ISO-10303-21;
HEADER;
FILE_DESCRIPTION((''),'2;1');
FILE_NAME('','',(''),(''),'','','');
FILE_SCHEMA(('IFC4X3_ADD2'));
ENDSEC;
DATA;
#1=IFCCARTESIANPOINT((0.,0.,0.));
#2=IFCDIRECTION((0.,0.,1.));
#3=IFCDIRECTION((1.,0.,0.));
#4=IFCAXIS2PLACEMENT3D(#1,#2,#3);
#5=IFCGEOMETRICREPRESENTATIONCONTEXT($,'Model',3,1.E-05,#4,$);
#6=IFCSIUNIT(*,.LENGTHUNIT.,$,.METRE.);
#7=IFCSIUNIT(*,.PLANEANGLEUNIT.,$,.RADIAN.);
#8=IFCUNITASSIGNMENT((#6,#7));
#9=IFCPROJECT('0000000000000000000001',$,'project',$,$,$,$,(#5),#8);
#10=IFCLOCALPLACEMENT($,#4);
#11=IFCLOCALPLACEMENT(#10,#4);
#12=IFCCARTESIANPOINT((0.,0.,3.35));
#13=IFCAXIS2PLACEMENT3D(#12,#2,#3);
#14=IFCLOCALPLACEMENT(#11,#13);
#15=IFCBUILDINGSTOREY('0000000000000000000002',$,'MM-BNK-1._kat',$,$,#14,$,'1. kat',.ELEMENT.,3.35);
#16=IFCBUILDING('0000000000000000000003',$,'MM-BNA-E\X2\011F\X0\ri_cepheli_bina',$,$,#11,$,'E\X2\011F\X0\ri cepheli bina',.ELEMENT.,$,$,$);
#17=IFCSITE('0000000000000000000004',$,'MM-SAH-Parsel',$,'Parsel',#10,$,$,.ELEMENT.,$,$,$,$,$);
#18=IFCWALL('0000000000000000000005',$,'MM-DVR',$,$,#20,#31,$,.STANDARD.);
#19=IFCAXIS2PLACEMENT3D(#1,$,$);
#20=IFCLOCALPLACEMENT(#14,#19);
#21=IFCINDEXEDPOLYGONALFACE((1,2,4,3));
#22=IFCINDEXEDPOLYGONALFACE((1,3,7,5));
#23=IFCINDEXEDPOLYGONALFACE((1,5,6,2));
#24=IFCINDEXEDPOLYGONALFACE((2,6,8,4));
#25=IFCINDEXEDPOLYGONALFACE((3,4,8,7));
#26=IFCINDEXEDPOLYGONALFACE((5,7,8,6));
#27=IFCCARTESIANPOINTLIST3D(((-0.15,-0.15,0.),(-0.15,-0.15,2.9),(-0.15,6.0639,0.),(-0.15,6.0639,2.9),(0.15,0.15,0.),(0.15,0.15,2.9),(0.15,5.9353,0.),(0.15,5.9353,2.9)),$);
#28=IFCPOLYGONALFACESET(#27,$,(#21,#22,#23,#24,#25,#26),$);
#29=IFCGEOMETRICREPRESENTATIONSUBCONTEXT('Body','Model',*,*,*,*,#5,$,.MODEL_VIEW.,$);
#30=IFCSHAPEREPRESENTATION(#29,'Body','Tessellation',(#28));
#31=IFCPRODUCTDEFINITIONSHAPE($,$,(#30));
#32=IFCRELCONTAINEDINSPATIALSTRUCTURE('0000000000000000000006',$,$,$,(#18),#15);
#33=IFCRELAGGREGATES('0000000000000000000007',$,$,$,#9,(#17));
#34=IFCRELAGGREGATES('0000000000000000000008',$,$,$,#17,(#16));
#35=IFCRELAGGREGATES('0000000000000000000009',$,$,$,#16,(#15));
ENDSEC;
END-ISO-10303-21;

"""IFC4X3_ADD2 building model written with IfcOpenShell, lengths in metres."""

from ifc_helpers import new_model, si_unit, frame, origin, origin_with_axes, place, context, subcontext, project, spatial, polyline, outline, extrude, element, save


model = new_model("IFC4X3_ADD2")

# Units and contexts
model_context = context("Model", 3, precision=1e-05, world=origin_with_axes())
body_context = subcontext(model_context, "Body", "Model", "MODEL_VIEW")
ifc_project = project(units=[si_unit("LENGTHUNIT", "METRE"), si_unit("PLANEANGLEUNIT", "RADIAN")], contexts=[model_context])

# Site, building, storey
site_placement = place(None, origin_with_axes())
site = spatial("IfcSite", under=ifc_project, at=site_placement, Name="MM-SAH-Parsel", ObjectType="Parsel", CompositionType="ELEMENT")
building_placement = place(site_placement, origin_with_axes())
building = spatial("IfcBuilding", under=site, at=building_placement, Name="MM-BNA-Eğri_cepheli_bina", LongName="Eğri cepheli bina", CompositionType="ELEMENT")
storey_placement = place(building_placement, frame((0.0, 0.0, 3.35), z_axis=(0.0, 0.0, 1.0), x_axis=(1.0, 0.0, 0.0)))
storey = spatial("IfcBuildingStorey", under=building, at=storey_placement, Name="MM-BNK-1._kat", LongName="1. kat", CompositionType="ELEMENT", Elevation=3.35)

# Wall
wall_1_placement = place(storey_placement, origin_with_axes())
element("IfcWall", 1, at=wall_1_placement, inside=storey, Name="MM-DVR", PredefinedType="STANDARD", context=body_context, shape_type="SweptSolid", body=[
    extrude(outline(polyline([(0.15, 5.9353), (0.15, 0.15), (-0.15, -0.15), (-0.15, 6.0639), (0.15, 5.9353)])), origin(), (0.0, 0.0, 1.0), 2.9),
])

save(model, "model.ifc")
